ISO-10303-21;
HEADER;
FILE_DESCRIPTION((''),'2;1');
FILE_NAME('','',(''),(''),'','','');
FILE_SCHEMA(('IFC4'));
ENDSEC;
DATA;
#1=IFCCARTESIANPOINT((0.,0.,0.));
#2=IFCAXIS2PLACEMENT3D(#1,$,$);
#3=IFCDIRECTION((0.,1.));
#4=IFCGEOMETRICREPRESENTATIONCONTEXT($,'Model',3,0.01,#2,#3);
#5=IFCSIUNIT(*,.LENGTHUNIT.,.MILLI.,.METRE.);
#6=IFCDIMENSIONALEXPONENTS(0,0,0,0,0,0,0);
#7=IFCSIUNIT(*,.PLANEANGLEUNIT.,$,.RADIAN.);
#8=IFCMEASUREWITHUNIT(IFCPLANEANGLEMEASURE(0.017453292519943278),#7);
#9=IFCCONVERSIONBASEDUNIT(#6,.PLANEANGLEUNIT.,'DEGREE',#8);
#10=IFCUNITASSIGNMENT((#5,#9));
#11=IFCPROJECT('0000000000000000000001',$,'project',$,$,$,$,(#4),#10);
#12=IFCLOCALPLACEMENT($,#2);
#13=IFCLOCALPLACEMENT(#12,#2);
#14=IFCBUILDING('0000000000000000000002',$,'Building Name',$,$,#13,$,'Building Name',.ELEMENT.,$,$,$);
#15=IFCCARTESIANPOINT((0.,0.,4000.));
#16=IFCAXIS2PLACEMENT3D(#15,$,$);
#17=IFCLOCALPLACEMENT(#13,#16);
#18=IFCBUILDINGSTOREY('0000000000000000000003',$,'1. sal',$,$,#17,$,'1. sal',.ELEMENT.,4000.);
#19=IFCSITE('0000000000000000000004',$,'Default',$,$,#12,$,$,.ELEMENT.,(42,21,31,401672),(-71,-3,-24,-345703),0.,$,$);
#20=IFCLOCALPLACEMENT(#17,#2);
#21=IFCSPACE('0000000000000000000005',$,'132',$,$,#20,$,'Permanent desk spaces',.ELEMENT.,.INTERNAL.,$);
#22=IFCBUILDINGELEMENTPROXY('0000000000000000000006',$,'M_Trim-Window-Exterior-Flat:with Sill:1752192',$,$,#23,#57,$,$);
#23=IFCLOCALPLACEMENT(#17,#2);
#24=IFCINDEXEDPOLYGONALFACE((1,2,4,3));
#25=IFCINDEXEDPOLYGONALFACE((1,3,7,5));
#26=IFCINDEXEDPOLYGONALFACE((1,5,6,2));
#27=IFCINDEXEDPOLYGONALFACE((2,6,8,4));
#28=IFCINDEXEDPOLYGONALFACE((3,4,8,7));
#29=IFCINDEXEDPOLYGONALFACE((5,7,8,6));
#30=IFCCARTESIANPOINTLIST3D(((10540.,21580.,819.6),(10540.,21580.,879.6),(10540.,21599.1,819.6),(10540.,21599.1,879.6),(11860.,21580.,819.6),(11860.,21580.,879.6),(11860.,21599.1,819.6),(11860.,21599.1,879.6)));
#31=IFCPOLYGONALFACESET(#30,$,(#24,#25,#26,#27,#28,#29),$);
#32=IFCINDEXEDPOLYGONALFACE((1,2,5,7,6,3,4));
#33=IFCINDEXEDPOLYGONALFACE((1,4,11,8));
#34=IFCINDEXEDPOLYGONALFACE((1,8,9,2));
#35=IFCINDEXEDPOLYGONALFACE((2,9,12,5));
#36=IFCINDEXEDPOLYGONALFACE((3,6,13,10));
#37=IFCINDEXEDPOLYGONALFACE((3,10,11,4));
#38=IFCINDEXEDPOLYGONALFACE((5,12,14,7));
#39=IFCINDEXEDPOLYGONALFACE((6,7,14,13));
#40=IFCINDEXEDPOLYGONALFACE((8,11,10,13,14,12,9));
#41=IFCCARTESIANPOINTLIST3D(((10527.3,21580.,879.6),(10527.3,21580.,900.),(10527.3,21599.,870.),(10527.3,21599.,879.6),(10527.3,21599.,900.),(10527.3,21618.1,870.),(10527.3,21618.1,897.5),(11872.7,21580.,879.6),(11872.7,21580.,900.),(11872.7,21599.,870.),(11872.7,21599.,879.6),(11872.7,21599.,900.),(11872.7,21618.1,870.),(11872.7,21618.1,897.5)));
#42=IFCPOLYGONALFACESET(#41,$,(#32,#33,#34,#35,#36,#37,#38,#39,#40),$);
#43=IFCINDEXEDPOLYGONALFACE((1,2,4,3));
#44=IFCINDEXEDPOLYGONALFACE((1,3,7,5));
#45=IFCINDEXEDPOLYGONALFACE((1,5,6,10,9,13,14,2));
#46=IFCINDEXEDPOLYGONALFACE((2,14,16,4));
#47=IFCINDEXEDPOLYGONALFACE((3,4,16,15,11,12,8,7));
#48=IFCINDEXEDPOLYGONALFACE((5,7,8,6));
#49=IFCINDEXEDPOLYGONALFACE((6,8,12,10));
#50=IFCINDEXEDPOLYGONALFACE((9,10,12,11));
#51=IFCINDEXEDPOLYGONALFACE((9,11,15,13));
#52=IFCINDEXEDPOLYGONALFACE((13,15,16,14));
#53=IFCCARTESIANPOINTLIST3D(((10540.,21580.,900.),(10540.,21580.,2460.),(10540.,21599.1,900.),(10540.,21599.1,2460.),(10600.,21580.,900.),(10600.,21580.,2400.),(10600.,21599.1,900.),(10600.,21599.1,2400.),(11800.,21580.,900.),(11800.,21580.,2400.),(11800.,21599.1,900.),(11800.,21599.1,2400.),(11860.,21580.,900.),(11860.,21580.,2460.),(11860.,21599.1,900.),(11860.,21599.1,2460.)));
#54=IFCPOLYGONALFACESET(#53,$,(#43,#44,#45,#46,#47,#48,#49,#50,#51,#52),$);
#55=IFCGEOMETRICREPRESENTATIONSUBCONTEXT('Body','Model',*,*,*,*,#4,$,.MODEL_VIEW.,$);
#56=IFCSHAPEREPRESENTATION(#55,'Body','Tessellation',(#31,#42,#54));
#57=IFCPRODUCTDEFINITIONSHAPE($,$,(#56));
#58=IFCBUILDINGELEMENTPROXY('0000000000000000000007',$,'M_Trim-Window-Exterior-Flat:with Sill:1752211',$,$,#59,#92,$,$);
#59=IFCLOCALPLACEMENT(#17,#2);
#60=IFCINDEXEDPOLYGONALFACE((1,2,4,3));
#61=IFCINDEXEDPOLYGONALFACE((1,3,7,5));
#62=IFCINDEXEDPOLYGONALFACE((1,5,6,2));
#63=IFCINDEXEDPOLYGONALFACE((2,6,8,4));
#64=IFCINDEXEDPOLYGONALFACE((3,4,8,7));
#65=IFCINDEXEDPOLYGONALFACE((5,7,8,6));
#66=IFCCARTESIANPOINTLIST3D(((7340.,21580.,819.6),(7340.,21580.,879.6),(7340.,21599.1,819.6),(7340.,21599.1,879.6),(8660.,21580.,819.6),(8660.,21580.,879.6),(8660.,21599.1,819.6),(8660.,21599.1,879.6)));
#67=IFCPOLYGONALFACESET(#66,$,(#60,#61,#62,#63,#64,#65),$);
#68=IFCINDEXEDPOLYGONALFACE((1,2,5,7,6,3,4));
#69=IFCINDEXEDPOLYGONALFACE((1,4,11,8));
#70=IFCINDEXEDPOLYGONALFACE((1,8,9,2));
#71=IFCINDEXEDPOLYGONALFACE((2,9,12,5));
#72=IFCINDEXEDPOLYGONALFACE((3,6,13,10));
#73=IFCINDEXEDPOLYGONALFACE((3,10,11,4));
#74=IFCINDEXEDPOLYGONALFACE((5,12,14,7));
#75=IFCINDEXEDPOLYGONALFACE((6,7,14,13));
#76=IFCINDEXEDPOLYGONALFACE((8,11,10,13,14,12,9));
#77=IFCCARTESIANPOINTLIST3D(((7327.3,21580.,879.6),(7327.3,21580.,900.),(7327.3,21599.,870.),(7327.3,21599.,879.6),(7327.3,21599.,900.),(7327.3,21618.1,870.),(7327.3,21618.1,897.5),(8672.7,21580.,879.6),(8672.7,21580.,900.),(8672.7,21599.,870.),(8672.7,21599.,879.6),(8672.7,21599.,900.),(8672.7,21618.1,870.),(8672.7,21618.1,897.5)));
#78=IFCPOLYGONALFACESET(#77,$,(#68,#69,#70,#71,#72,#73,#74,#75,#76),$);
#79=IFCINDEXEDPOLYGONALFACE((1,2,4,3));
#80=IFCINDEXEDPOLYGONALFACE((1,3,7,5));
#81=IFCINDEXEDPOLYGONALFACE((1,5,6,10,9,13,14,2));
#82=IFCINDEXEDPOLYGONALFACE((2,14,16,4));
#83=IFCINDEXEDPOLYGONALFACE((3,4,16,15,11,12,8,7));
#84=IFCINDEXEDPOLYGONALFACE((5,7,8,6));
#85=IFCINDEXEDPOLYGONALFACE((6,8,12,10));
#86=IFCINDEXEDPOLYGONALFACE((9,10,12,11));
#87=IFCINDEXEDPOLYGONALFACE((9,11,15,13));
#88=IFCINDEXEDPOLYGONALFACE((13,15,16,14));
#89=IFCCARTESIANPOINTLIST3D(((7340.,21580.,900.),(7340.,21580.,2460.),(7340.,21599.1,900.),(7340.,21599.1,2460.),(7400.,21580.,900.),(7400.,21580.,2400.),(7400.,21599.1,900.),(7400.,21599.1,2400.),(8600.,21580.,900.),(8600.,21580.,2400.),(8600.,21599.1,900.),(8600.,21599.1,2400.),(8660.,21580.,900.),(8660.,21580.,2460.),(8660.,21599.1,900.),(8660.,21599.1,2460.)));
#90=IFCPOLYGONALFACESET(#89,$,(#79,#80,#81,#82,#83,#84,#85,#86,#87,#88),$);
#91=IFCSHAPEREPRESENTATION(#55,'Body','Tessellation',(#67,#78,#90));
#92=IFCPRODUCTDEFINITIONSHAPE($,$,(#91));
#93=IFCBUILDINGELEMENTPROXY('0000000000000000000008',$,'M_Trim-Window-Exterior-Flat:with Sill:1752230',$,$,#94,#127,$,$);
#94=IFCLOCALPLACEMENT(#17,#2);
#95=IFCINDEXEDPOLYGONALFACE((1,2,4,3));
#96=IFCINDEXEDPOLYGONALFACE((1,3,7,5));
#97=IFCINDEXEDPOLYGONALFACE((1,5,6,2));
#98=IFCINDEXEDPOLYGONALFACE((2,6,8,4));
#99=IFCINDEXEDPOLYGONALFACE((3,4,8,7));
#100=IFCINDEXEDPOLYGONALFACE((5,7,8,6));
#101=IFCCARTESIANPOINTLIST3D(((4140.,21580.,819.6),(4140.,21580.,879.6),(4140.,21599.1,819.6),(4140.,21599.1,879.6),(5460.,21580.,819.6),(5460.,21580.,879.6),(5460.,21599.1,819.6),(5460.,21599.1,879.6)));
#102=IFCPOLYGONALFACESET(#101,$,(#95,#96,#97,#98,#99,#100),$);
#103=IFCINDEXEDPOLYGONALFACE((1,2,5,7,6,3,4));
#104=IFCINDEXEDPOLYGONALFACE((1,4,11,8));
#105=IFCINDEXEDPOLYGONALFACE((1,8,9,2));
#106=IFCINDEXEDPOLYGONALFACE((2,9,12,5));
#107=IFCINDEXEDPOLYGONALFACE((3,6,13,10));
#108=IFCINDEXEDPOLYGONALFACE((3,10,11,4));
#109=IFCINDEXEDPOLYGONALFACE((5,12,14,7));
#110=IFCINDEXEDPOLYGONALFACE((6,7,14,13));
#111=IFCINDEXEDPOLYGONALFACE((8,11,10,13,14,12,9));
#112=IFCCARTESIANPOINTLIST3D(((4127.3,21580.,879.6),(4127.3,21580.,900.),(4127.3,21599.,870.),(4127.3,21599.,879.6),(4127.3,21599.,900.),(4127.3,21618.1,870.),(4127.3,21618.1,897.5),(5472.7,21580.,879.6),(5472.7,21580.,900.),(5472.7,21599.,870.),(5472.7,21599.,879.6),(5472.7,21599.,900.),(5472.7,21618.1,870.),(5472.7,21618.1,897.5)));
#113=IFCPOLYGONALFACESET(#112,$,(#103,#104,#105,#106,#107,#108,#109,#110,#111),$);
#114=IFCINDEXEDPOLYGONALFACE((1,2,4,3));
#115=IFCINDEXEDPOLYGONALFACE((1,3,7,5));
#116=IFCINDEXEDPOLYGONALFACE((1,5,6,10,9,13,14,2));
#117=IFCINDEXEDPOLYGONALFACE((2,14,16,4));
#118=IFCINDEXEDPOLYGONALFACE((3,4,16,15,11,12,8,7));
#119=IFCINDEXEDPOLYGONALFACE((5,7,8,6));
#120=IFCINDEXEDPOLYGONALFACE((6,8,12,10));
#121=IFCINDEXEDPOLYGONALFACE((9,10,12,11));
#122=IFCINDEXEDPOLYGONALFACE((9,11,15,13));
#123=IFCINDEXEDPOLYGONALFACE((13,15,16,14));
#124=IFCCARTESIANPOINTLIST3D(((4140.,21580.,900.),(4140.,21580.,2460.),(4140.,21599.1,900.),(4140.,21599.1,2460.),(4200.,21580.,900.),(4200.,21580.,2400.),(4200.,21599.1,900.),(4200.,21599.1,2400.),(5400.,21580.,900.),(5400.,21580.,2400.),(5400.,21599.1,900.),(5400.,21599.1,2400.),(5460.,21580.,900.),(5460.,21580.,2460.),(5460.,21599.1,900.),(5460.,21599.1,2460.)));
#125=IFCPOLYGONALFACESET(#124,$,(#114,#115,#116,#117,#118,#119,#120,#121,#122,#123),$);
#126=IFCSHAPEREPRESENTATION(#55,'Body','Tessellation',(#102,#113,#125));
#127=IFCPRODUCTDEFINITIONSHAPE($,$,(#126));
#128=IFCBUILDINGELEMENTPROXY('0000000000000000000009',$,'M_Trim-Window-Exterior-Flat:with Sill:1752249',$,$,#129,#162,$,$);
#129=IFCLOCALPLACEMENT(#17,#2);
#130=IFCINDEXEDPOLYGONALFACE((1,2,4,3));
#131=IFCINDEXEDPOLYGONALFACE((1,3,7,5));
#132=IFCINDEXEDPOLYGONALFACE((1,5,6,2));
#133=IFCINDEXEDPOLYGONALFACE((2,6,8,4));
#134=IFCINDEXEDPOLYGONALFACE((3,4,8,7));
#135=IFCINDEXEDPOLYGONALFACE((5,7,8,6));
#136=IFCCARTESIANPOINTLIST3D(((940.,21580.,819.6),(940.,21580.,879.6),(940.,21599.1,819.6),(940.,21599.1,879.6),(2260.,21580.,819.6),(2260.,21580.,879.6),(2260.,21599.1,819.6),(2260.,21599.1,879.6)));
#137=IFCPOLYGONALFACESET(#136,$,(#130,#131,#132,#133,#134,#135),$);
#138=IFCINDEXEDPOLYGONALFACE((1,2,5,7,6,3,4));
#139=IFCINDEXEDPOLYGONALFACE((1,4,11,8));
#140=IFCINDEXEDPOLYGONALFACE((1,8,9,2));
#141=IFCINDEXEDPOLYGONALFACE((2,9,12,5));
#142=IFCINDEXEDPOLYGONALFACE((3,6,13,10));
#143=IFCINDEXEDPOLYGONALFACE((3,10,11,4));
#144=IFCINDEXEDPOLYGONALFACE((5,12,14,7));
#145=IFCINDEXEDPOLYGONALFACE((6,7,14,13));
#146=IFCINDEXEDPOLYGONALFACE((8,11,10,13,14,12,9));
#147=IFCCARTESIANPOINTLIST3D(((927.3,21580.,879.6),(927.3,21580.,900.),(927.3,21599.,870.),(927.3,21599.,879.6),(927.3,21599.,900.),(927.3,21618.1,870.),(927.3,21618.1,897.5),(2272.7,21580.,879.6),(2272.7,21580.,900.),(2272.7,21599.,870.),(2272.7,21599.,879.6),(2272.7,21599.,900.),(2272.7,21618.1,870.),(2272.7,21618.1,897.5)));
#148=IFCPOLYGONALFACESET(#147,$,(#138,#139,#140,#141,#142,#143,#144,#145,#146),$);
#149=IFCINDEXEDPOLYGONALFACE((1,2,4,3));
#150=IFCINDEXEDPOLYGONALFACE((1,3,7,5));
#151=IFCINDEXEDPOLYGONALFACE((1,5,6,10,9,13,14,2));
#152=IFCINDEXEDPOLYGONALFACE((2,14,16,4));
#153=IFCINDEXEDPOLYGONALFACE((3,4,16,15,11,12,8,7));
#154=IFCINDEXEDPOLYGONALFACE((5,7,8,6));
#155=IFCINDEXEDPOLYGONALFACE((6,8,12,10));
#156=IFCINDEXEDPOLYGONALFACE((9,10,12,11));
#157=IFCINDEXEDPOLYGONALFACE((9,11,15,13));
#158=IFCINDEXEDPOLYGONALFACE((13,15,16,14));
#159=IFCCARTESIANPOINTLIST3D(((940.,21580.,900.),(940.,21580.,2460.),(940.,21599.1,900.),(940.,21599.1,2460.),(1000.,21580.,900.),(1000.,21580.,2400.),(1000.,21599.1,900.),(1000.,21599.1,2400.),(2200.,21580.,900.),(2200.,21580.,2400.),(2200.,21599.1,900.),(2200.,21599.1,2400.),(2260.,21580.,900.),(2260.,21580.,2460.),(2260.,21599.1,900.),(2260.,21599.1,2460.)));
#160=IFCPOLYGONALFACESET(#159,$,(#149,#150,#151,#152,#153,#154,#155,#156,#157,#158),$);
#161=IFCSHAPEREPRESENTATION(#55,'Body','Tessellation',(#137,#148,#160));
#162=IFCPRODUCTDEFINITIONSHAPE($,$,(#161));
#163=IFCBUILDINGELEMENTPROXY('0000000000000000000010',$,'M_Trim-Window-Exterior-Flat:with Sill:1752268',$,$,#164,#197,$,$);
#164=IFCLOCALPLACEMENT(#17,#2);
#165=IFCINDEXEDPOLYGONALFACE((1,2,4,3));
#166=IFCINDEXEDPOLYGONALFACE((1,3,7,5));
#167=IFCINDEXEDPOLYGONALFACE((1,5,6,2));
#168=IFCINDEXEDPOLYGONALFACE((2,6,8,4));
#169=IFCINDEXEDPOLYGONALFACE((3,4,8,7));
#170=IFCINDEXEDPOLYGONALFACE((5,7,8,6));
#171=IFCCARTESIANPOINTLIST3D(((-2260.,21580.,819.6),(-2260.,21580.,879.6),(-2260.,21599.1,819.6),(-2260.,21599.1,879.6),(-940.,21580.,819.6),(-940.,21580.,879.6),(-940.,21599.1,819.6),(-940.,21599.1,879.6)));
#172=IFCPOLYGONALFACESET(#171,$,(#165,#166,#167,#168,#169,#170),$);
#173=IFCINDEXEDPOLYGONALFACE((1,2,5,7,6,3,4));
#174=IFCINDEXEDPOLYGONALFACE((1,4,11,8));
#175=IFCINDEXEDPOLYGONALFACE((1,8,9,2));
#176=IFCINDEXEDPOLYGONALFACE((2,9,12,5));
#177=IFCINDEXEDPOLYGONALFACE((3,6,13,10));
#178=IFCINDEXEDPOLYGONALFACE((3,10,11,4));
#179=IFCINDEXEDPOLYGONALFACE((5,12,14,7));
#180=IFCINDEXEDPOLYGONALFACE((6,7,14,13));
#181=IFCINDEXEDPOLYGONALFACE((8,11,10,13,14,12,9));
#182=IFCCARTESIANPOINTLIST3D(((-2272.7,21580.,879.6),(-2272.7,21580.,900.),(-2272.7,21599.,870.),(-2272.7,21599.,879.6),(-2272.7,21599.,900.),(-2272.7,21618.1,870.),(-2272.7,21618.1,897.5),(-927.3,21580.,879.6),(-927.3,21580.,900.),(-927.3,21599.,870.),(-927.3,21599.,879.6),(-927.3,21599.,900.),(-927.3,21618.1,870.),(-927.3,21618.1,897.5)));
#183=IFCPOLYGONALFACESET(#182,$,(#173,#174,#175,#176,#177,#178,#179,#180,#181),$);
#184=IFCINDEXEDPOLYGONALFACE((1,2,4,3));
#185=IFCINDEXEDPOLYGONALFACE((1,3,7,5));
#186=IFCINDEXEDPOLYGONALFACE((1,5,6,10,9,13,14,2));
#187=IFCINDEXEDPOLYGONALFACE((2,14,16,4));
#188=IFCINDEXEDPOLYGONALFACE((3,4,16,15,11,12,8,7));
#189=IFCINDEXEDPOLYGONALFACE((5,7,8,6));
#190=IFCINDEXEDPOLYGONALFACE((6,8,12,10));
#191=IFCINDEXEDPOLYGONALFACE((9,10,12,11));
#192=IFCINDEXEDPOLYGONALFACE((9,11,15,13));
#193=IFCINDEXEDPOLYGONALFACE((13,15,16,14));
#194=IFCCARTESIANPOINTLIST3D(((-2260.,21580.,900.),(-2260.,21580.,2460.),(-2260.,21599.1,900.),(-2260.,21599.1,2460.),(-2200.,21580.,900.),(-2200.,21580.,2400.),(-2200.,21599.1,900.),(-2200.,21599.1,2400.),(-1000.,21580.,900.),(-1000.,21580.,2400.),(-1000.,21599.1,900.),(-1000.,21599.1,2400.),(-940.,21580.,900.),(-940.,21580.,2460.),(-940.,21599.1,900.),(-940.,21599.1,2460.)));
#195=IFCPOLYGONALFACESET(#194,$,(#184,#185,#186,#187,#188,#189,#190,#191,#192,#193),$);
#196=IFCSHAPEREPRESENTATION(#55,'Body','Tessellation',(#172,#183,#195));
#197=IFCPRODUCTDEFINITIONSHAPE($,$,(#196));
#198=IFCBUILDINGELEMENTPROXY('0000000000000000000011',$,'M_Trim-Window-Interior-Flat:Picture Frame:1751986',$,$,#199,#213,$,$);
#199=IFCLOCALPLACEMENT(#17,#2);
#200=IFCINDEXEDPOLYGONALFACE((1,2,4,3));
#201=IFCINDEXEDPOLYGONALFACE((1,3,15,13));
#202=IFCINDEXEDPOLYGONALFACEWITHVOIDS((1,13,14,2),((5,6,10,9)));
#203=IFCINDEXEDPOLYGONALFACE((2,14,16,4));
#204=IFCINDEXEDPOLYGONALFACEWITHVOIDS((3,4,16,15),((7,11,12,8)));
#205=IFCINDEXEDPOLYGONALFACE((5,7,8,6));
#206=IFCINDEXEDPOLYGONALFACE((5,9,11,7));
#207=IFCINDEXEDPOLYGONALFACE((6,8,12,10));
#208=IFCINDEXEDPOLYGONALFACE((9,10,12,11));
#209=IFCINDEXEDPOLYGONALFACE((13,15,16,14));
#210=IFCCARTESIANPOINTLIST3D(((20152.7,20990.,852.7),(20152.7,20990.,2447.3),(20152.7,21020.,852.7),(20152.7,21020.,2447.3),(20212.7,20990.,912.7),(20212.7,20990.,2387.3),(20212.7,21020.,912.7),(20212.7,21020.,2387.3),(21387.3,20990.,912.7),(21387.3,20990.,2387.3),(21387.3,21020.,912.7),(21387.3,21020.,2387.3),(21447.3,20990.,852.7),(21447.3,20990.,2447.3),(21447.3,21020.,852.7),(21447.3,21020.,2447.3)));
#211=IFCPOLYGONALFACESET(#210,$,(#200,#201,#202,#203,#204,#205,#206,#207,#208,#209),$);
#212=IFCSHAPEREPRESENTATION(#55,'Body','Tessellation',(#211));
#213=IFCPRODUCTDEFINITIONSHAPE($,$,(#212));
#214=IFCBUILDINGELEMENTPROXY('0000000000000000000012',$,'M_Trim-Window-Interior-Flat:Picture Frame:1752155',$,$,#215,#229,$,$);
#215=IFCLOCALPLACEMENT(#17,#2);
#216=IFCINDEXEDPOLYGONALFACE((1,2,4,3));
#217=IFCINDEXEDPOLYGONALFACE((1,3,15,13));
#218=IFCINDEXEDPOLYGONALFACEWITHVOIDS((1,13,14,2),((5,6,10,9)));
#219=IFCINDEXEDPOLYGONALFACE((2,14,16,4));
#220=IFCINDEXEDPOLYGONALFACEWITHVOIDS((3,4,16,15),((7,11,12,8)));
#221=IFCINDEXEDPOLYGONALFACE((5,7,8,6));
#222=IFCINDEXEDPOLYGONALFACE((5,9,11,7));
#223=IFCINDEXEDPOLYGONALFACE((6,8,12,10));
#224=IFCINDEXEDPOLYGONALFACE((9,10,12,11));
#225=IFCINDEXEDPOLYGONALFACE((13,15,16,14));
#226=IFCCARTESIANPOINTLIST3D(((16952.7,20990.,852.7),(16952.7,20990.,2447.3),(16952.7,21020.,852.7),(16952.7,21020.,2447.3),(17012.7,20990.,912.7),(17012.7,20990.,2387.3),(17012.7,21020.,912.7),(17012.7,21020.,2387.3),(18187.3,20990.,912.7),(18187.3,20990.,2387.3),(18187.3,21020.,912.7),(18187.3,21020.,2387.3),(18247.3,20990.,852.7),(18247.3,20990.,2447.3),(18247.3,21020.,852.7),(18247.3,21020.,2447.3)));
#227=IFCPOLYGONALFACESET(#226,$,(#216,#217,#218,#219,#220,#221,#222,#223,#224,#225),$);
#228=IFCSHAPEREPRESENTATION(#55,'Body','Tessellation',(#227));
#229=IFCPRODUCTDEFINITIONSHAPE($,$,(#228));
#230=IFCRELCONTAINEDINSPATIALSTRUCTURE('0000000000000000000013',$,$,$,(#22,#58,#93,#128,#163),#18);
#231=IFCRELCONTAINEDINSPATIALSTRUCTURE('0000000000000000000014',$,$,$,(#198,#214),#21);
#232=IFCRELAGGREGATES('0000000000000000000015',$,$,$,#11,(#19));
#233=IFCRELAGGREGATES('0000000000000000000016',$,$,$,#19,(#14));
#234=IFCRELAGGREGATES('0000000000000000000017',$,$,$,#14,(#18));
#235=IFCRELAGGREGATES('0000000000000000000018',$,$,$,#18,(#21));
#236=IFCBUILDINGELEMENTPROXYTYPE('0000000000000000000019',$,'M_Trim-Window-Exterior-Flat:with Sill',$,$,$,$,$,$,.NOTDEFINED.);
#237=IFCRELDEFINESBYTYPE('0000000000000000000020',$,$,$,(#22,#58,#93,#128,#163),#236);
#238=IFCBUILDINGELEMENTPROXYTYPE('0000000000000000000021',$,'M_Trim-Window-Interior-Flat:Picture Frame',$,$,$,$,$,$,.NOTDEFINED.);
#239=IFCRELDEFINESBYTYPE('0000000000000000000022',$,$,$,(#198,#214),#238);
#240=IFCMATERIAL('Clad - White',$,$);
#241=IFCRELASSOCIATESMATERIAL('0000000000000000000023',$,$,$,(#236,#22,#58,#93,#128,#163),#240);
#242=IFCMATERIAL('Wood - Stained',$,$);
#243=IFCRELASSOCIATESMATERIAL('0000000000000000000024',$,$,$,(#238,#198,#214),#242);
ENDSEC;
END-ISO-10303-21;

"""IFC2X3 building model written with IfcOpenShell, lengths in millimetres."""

from ifc_helpers import new_model, entity, si_unit, converted_unit, direction, frame, frame_2d, origin, place, context, subcontext, project, spatial, polyline, rectangle, outline, extrude, source, transform, mapped, material, type_object, type_shapes, element, save


model = new_model("IFC2X3")

# Units and contexts
model_context = context("Model", 3, precision=0.01, world=origin(), true_north=direction((0.0, 1.0)))
body_context = subcontext(model_context, "Body", "Model", "MODEL_VIEW")
ifc_project = project(units=[si_unit("LENGTHUNIT", "METRE", prefix="MILLI"), converted_unit("PLANEANGLEUNIT", "DEGREE", entity("IfcPlaneAngleMeasure", 0.017453292519943278), si_unit("PLANEANGLEUNIT", "RADIAN"), dimensions=[0, 0, 0, 0, 0, 0, 0])], contexts=[model_context])

# Site, building, storey
site_placement = place(None, origin())
site = spatial("IfcSite", under=ifc_project, at=site_placement, Name="Default", CompositionType="ELEMENT", RefLatitude=(42, 21, 31, 401672), RefLongitude=(-71, -3, -24, -345703), RefElevation=0.0)
building_placement = place(site_placement, origin())
building = spatial("IfcBuilding", under=site, at=building_placement, Name="Building Name", LongName="Building Name", CompositionType="ELEMENT")
storey_placement = place(building_placement, frame((0.0, 0.0, 4000.0)))
storey = spatial("IfcBuildingStorey", under=building, at=storey_placement, Name="1. sal", LongName="1. sal", CompositionType="ELEMENT", Elevation=4000.0)

# Building element proxies
ifc_material_1 = material(Name="Clad - White")
ifc_material_2 = material(Name="Wood - Stained")
building_element_proxy_type_1 = type_object("IfcBuildingElementProxyType", Name="M_Trim-Window-Exterior-Flat:with Sill", PredefinedType="NOTDEFINED", material=ifc_material_1)
shared_shape_1 = source(origin(), body_context, "Body", "SweptSolid", [
    extrude(rectangle(XDim=1320.0, YDim=60.0, at=frame_2d((0.0, 0.0), x_axis=(1.0, 0.0))), frame((0.0, -1550.4, 0.0), z_axis=(0.0, 0.0, 1.0), x_axis=(-1.0, 0.0, 0.0)), (0.0, 0.0, 1.0), 19.0),
    extrude(outline(polyline([(-19.0, -15.2), (0.0, -15.2), (0.0, -5.7), (19.0, -5.7), (19.0, 14.8), (0.0, 14.8), (-19.0, 12.3), (-19.0, -15.2)])), frame((-672.7, -1514.8, 19.0), z_axis=(1.0, 0.0, 0.0), x_axis=(0.0, 0.0, -1.0)), (0.0, 0.0, 1.0), 1345.4),
    extrude(outline(polyline([(-795.0, -660.0), (765.0, -660.0), (765.0, -600.0), (-735.0, -600.0), (-735.0, 600.0), (765.0, 600.0), (765.0, 660.0), (-795.0, 660.0), (-795.0, -660.0)])), frame((0.0, -735.0, 0.0), z_axis=(0.0, 0.0, 1.0), x_axis=(0.0, -1.0, 0.0)), (0.0, 0.0, 1.0), 19.0),
])
type_shapes(building_element_proxy_type_1, [shared_shape_1])
for number, where, z_axis, x_axis, name in (
    (1, (11200.0, 21580.0, 2400.0), (0.0, 1.0, 0.0), (-1.0, 0.0, 0.0), "M_Trim-Window-Exterior-Flat:with Sill:1752192"),
    (2, (8000.0, 21580.0, 2400.0), (0.0, 1.0, 0.0), (-1.0, 0.0, 0.0), "M_Trim-Window-Exterior-Flat:with Sill:1752211"),
    (3, (4800.0, 21580.0, 2400.0), (0.0, 1.0, 0.0), (-1.0, 0.0, 0.0), "M_Trim-Window-Exterior-Flat:with Sill:1752230"),
    (4, (1600.0, 21580.0, 2400.0), (0.0, 1.0, 0.0), (-1.0, 0.0, 0.0), "M_Trim-Window-Exterior-Flat:with Sill:1752249"),
    (5, (-1600.0, 21580.0, 2400.0), (0.0, 1.0, 0.0), (-1.0, 0.0, 0.0), "M_Trim-Window-Exterior-Flat:with Sill:1752268"),
):
    element("IfcBuildingElementProxy", number, at=place(storey_placement, frame(where, z_axis=z_axis, x_axis=x_axis)), inside=storey, type_object=building_element_proxy_type_1, material=ifc_material_1, Name=name, context=body_context, shape_type="MappedRepresentation", body=[
        mapped(shared_shape_1, transform((0.0, 0.0, 0.0), scale=1.0)),
    ])

# Shared definitions
space_placement = place(storey_placement, origin())
space = spatial("IfcSpace", under=storey, at=space_placement, Name="132", LongName="Permanent desk spaces", CompositionType="ELEMENT", InteriorOrExteriorSpace="INTERNAL")

# Building element proxies
building_element_proxy_type_2 = type_object("IfcBuildingElementProxyType", Name="M_Trim-Window-Interior-Flat:Picture Frame", PredefinedType="NOTDEFINED", material=ifc_material_2)
shared_shape_2 = source(origin(), body_context, "Body", "SweptSolid", [
    extrude(outline(polyline([(-647.3, -797.3), (647.3, -797.3), (647.3, 797.3), (-647.3, 797.3), (-647.3, -797.3)]), holes=[polyline([(-587.3, -737.3), (-587.3, 737.3), (587.3, 737.3), (587.3, -737.3), (-587.3, -737.3)])]), frame((0.0, -750.0, 0.0), z_axis=(0.0, 0.0, 1.0), x_axis=(-1.0, 0.0, 0.0)), (0.0, 0.0, 1.0), 30.0),
])
type_shapes(building_element_proxy_type_2, [shared_shape_2])
for number, where, z_axis, x_axis, name in (
    (6, (20800.0, 21020.0, 2400.0), (0.0, -1.0, 0.0), (1.0, 0.0, 0.0), "M_Trim-Window-Interior-Flat:Picture Frame:1751986"),
    (7, (17600.0, 21020.0, 2400.0), (0.0, -1.0, 0.0), (1.0, 0.0, 0.0), "M_Trim-Window-Interior-Flat:Picture Frame:1752155"),
):
    element("IfcBuildingElementProxy", number, at=place(space_placement, frame(where, z_axis=z_axis, x_axis=x_axis)), inside=space, type_object=building_element_proxy_type_2, material=ifc_material_2, Name=name, context=body_context, shape_type="MappedRepresentation", body=[
        mapped(shared_shape_2, transform((0.0, 0.0, 0.0), scale=1.0)),
    ])

save(model, "model.ifc")
